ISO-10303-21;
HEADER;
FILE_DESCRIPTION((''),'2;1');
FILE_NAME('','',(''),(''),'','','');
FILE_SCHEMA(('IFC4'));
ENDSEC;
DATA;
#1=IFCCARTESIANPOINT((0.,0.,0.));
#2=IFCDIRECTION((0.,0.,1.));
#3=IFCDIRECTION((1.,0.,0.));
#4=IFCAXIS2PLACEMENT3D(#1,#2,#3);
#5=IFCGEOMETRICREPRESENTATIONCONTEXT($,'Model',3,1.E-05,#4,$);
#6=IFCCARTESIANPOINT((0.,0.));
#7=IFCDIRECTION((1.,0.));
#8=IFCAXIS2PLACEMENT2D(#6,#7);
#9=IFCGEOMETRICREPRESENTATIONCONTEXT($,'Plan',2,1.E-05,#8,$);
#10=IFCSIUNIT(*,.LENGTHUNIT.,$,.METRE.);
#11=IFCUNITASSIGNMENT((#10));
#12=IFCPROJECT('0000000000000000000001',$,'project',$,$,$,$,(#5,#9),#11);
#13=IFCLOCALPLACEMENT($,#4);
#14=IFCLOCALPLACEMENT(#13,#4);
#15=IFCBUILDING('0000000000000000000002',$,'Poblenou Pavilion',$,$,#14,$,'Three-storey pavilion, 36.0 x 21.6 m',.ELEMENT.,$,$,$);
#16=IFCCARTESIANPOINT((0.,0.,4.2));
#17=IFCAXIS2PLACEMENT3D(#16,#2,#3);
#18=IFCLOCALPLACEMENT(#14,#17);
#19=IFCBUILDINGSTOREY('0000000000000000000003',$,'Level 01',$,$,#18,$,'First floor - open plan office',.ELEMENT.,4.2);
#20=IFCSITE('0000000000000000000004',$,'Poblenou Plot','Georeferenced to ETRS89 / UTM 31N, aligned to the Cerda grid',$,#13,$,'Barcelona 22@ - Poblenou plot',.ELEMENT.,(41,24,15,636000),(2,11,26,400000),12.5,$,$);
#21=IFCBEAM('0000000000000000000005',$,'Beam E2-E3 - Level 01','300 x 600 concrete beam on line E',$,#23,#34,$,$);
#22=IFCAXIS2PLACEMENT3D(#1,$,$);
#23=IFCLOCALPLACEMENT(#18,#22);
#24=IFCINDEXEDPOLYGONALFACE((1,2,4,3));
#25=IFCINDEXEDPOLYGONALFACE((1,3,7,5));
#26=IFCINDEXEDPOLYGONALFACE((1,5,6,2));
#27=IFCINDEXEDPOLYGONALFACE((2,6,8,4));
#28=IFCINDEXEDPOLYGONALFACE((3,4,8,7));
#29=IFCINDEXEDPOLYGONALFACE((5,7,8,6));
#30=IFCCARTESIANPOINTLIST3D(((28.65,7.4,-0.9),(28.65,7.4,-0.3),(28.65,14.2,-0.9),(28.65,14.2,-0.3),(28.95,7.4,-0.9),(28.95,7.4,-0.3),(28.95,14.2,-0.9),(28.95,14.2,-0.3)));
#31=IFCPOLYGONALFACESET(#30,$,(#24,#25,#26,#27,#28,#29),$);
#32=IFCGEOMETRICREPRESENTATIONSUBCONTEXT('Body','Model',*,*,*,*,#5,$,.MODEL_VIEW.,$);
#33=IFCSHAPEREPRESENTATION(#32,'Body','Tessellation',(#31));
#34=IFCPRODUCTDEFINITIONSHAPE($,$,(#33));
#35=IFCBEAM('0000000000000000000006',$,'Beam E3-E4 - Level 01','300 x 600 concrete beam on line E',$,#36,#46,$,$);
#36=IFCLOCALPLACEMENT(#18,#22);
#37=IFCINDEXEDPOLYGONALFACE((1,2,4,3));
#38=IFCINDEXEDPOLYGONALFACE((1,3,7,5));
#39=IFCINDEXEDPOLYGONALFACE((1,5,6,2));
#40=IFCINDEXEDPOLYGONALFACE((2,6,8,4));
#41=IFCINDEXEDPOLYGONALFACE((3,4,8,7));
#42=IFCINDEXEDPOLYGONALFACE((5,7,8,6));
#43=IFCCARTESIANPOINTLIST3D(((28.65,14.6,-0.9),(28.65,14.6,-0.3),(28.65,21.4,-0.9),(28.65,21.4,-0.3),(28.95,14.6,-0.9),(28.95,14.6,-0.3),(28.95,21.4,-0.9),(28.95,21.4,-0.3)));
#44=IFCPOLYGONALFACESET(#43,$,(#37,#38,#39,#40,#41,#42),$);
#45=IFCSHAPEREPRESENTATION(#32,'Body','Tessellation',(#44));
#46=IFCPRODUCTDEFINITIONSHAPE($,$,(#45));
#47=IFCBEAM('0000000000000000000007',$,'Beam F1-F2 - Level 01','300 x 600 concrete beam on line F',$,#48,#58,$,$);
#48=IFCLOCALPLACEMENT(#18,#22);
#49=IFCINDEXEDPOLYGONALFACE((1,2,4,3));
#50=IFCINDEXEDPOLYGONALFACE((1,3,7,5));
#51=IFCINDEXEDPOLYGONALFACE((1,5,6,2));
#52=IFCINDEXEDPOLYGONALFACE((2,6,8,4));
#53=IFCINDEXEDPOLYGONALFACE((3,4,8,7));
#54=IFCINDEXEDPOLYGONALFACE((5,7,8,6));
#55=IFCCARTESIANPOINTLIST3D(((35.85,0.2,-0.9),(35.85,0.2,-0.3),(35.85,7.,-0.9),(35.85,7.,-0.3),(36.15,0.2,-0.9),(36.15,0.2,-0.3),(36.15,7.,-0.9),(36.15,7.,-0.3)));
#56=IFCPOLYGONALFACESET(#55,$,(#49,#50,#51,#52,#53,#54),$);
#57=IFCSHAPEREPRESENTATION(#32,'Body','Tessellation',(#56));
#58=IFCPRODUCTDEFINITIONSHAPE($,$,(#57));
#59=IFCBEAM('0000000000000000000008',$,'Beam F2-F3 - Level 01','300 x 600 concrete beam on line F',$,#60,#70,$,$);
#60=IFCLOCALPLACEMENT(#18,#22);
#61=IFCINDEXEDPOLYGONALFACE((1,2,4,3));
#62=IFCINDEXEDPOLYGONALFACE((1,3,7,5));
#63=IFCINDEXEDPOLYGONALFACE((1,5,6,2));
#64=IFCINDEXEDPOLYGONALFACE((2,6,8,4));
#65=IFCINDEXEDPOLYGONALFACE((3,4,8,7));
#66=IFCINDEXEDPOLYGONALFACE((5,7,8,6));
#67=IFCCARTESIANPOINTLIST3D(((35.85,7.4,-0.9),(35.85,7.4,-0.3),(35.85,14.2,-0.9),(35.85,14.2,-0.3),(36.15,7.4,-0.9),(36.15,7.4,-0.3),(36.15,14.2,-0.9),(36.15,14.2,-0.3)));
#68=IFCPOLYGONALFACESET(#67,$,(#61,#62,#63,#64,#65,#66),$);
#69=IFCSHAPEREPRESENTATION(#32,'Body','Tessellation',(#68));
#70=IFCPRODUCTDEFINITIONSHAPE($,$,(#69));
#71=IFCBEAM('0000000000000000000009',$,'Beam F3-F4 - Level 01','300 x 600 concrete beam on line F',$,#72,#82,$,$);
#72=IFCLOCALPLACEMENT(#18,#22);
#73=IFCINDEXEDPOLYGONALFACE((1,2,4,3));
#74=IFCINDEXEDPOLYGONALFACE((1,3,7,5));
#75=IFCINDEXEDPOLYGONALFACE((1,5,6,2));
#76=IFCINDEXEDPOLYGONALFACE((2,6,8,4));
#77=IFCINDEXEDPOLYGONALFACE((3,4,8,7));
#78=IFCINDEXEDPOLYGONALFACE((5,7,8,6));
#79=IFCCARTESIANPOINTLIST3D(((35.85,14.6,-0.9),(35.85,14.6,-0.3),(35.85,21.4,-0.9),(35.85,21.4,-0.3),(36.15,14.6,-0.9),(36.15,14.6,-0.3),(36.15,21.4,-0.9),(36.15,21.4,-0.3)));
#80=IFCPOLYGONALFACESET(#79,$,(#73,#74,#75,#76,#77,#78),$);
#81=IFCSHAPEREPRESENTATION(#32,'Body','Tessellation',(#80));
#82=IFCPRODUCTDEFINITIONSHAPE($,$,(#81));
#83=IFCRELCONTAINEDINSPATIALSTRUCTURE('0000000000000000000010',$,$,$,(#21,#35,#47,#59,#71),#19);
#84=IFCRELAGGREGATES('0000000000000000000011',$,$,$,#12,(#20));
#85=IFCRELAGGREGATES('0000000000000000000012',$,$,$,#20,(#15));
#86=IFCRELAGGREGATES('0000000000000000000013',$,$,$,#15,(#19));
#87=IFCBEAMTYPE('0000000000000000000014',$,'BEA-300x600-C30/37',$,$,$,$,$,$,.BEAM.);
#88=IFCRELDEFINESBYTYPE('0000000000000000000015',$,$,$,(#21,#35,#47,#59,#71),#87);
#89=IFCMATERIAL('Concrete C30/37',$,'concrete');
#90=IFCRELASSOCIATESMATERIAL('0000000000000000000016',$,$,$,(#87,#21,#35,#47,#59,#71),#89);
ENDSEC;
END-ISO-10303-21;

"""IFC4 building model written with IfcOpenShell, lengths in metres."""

from ifc_helpers import new_model, si_unit, frame, origin_with_axes, origin_2d_with_axis, place, context, subcontext, project, spatial, line, indexed_curve, rectangle, outline, extrude, material, material_profile, profile_set, profile_usage, type_object, element, save


model = new_model("IFC4")

# Units and contexts
model_context = context("Model", 3, precision=1e-05, world=origin_with_axes())
plan_context = context("Plan", 2, precision=1e-05, world=origin_2d_with_axis())
body_context = subcontext(model_context, "Body", "Model", "MODEL_VIEW")
ifc_project = project(units=[si_unit("LENGTHUNIT", "METRE")], contexts=[model_context, plan_context])

# Site, building, storey
site_placement = place(None, origin_with_axes())
site = spatial("IfcSite", under=ifc_project, at=site_placement, Name="Poblenou Plot", Description="Georeferenced to ETRS89 / UTM 31N, aligned to the Cerda grid", LongName="Barcelona 22@ - Poblenou plot", CompositionType="ELEMENT", RefLatitude=(41, 24, 15, 636000), RefLongitude=(2, 11, 26, 400000), RefElevation=12.5)
building_placement = place(site_placement, origin_with_axes())
building = spatial("IfcBuilding", under=site, at=building_placement, Name="Poblenou Pavilion", LongName="Three-storey pavilion, 36.0 x 21.6 m", CompositionType="ELEMENT")
storey_placement = place(building_placement, frame((0.0, 0.0, 4.2), z_axis=(0.0, 0.0, 1.0), x_axis=(1.0, 0.0, 0.0)))
storey = spatial("IfcBuildingStorey", under=building, at=storey_placement, Name="Level 01", LongName="First floor - open plan office", CompositionType="ELEMENT", Elevation=4.2)

# Shared definitions
ifc_material = material(Name="Concrete C30/37", Category="concrete")

# Beams
ifc_material_profile_1 = material_profile(ifc_material, rectangle(XDim=0.3, YDim=0.6))
ifc_profile_set_1 = profile_set([ifc_material_profile_1], Name="BEA-300x600-C30/37")
beam_type = type_object("IfcBeamType", Name="BEA-300x600-C30/37", PredefinedType="BEAM", material=ifc_profile_set_1)
ifc_profile_usage_1 = profile_usage(ifc_profile_set_1)
beam_1_placement = place(storey_placement, frame((28.65, 7.4, -0.9), z_axis=(0.0, 1.0, 0.0), x_axis=(0.0, 0.0, 1.0)))
element("IfcBeam", 1, at=beam_1_placement, inside=storey, type_object=beam_type, material=ifc_profile_usage_1, Name="Beam E2-E3 - Level 01", Description="300 x 600 concrete beam on line E", context=body_context, shape_type="SweptSolid", body=[
    extrude(outline(indexed_curve([(0.0, 0.0), (0.6, 0.0), (0.6, 0.3), (0.0, 0.3)], segments=[line(1, 2, 3, 4, 1)])), origin_with_axes(), (0.0, 0.0, 1.0), 6.8),
])
ifc_profile_usage_2 = profile_usage(ifc_profile_set_1)
beam_2_placement = place(storey_placement, frame((28.65, 14.6, -0.9), z_axis=(0.0, 1.0, 0.0), x_axis=(0.0, 0.0, 1.0)))
element("IfcBeam", 2, at=beam_2_placement, inside=storey, type_object=beam_type, material=ifc_profile_usage_2, Name="Beam E3-E4 - Level 01", Description="300 x 600 concrete beam on line E", context=body_context, shape_type="SweptSolid", body=[
    extrude(outline(indexed_curve([(0.0, 0.0), (0.6, 0.0), (0.6, 0.3), (0.0, 0.3)], segments=[line(1, 2, 3, 4, 1)])), origin_with_axes(), (0.0, 0.0, 1.0), 6.8),
])
ifc_profile_usage_3 = profile_usage(ifc_profile_set_1)
beam_3_placement = place(storey_placement, frame((35.85, 0.2, -0.9), z_axis=(0.0, 1.0, 0.0), x_axis=(0.0, 0.0, 1.0)))
element("IfcBeam", 3, at=beam_3_placement, inside=storey, type_object=beam_type, material=ifc_profile_usage_3, Name="Beam F1-F2 - Level 01", Description="300 x 600 concrete beam on line F", context=body_context, shape_type="SweptSolid", body=[
    extrude(outline(indexed_curve([(0.0, 0.0), (0.6, 0.0), (0.6, 0.3), (0.0, 0.3)], segments=[line(1, 2, 3, 4, 1)])), origin_with_axes(), (0.0, 0.0, 1.0), 6.8),
])
ifc_profile_usage_4 = profile_usage(ifc_profile_set_1)
beam_4_placement = place(storey_placement, frame((35.85, 7.4, -0.9), z_axis=(0.0, 1.0, 0.0), x_axis=(0.0, 0.0, 1.0)))
element("IfcBeam", 4, at=beam_4_placement, inside=storey, type_object=beam_type, material=ifc_profile_usage_4, Name="Beam F2-F3 - Level 01", Description="300 x 600 concrete beam on line F", context=body_context, shape_type="SweptSolid", body=[
    extrude(outline(indexed_curve([(0.0, 0.0), (0.6, 0.0), (0.6, 0.3), (0.0, 0.3)], segments=[line(1, 2, 3, 4, 1)])), origin_with_axes(), (0.0, 0.0, 1.0), 6.8),
])
ifc_profile_usage_5 = profile_usage(ifc_profile_set_1)
beam_5_placement = place(storey_placement, frame((35.85, 14.6, -0.9), z_axis=(0.0, 1.0, 0.0), x_axis=(0.0, 0.0, 1.0)))
element("IfcBeam", 5, at=beam_5_placement, inside=storey, type_object=beam_type, material=ifc_profile_usage_5, Name="Beam F3-F4 - Level 01", Description="300 x 600 concrete beam on line F", context=body_context, shape_type="SweptSolid", body=[
    extrude(outline(indexed_curve([(0.0, 0.0), (0.6, 0.0), (0.6, 0.3), (0.0, 0.3)], segments=[line(1, 2, 3, 4, 1)])), origin_with_axes(), (0.0, 0.0, 1.0), 6.8),
])

save(model, "model.ifc")
